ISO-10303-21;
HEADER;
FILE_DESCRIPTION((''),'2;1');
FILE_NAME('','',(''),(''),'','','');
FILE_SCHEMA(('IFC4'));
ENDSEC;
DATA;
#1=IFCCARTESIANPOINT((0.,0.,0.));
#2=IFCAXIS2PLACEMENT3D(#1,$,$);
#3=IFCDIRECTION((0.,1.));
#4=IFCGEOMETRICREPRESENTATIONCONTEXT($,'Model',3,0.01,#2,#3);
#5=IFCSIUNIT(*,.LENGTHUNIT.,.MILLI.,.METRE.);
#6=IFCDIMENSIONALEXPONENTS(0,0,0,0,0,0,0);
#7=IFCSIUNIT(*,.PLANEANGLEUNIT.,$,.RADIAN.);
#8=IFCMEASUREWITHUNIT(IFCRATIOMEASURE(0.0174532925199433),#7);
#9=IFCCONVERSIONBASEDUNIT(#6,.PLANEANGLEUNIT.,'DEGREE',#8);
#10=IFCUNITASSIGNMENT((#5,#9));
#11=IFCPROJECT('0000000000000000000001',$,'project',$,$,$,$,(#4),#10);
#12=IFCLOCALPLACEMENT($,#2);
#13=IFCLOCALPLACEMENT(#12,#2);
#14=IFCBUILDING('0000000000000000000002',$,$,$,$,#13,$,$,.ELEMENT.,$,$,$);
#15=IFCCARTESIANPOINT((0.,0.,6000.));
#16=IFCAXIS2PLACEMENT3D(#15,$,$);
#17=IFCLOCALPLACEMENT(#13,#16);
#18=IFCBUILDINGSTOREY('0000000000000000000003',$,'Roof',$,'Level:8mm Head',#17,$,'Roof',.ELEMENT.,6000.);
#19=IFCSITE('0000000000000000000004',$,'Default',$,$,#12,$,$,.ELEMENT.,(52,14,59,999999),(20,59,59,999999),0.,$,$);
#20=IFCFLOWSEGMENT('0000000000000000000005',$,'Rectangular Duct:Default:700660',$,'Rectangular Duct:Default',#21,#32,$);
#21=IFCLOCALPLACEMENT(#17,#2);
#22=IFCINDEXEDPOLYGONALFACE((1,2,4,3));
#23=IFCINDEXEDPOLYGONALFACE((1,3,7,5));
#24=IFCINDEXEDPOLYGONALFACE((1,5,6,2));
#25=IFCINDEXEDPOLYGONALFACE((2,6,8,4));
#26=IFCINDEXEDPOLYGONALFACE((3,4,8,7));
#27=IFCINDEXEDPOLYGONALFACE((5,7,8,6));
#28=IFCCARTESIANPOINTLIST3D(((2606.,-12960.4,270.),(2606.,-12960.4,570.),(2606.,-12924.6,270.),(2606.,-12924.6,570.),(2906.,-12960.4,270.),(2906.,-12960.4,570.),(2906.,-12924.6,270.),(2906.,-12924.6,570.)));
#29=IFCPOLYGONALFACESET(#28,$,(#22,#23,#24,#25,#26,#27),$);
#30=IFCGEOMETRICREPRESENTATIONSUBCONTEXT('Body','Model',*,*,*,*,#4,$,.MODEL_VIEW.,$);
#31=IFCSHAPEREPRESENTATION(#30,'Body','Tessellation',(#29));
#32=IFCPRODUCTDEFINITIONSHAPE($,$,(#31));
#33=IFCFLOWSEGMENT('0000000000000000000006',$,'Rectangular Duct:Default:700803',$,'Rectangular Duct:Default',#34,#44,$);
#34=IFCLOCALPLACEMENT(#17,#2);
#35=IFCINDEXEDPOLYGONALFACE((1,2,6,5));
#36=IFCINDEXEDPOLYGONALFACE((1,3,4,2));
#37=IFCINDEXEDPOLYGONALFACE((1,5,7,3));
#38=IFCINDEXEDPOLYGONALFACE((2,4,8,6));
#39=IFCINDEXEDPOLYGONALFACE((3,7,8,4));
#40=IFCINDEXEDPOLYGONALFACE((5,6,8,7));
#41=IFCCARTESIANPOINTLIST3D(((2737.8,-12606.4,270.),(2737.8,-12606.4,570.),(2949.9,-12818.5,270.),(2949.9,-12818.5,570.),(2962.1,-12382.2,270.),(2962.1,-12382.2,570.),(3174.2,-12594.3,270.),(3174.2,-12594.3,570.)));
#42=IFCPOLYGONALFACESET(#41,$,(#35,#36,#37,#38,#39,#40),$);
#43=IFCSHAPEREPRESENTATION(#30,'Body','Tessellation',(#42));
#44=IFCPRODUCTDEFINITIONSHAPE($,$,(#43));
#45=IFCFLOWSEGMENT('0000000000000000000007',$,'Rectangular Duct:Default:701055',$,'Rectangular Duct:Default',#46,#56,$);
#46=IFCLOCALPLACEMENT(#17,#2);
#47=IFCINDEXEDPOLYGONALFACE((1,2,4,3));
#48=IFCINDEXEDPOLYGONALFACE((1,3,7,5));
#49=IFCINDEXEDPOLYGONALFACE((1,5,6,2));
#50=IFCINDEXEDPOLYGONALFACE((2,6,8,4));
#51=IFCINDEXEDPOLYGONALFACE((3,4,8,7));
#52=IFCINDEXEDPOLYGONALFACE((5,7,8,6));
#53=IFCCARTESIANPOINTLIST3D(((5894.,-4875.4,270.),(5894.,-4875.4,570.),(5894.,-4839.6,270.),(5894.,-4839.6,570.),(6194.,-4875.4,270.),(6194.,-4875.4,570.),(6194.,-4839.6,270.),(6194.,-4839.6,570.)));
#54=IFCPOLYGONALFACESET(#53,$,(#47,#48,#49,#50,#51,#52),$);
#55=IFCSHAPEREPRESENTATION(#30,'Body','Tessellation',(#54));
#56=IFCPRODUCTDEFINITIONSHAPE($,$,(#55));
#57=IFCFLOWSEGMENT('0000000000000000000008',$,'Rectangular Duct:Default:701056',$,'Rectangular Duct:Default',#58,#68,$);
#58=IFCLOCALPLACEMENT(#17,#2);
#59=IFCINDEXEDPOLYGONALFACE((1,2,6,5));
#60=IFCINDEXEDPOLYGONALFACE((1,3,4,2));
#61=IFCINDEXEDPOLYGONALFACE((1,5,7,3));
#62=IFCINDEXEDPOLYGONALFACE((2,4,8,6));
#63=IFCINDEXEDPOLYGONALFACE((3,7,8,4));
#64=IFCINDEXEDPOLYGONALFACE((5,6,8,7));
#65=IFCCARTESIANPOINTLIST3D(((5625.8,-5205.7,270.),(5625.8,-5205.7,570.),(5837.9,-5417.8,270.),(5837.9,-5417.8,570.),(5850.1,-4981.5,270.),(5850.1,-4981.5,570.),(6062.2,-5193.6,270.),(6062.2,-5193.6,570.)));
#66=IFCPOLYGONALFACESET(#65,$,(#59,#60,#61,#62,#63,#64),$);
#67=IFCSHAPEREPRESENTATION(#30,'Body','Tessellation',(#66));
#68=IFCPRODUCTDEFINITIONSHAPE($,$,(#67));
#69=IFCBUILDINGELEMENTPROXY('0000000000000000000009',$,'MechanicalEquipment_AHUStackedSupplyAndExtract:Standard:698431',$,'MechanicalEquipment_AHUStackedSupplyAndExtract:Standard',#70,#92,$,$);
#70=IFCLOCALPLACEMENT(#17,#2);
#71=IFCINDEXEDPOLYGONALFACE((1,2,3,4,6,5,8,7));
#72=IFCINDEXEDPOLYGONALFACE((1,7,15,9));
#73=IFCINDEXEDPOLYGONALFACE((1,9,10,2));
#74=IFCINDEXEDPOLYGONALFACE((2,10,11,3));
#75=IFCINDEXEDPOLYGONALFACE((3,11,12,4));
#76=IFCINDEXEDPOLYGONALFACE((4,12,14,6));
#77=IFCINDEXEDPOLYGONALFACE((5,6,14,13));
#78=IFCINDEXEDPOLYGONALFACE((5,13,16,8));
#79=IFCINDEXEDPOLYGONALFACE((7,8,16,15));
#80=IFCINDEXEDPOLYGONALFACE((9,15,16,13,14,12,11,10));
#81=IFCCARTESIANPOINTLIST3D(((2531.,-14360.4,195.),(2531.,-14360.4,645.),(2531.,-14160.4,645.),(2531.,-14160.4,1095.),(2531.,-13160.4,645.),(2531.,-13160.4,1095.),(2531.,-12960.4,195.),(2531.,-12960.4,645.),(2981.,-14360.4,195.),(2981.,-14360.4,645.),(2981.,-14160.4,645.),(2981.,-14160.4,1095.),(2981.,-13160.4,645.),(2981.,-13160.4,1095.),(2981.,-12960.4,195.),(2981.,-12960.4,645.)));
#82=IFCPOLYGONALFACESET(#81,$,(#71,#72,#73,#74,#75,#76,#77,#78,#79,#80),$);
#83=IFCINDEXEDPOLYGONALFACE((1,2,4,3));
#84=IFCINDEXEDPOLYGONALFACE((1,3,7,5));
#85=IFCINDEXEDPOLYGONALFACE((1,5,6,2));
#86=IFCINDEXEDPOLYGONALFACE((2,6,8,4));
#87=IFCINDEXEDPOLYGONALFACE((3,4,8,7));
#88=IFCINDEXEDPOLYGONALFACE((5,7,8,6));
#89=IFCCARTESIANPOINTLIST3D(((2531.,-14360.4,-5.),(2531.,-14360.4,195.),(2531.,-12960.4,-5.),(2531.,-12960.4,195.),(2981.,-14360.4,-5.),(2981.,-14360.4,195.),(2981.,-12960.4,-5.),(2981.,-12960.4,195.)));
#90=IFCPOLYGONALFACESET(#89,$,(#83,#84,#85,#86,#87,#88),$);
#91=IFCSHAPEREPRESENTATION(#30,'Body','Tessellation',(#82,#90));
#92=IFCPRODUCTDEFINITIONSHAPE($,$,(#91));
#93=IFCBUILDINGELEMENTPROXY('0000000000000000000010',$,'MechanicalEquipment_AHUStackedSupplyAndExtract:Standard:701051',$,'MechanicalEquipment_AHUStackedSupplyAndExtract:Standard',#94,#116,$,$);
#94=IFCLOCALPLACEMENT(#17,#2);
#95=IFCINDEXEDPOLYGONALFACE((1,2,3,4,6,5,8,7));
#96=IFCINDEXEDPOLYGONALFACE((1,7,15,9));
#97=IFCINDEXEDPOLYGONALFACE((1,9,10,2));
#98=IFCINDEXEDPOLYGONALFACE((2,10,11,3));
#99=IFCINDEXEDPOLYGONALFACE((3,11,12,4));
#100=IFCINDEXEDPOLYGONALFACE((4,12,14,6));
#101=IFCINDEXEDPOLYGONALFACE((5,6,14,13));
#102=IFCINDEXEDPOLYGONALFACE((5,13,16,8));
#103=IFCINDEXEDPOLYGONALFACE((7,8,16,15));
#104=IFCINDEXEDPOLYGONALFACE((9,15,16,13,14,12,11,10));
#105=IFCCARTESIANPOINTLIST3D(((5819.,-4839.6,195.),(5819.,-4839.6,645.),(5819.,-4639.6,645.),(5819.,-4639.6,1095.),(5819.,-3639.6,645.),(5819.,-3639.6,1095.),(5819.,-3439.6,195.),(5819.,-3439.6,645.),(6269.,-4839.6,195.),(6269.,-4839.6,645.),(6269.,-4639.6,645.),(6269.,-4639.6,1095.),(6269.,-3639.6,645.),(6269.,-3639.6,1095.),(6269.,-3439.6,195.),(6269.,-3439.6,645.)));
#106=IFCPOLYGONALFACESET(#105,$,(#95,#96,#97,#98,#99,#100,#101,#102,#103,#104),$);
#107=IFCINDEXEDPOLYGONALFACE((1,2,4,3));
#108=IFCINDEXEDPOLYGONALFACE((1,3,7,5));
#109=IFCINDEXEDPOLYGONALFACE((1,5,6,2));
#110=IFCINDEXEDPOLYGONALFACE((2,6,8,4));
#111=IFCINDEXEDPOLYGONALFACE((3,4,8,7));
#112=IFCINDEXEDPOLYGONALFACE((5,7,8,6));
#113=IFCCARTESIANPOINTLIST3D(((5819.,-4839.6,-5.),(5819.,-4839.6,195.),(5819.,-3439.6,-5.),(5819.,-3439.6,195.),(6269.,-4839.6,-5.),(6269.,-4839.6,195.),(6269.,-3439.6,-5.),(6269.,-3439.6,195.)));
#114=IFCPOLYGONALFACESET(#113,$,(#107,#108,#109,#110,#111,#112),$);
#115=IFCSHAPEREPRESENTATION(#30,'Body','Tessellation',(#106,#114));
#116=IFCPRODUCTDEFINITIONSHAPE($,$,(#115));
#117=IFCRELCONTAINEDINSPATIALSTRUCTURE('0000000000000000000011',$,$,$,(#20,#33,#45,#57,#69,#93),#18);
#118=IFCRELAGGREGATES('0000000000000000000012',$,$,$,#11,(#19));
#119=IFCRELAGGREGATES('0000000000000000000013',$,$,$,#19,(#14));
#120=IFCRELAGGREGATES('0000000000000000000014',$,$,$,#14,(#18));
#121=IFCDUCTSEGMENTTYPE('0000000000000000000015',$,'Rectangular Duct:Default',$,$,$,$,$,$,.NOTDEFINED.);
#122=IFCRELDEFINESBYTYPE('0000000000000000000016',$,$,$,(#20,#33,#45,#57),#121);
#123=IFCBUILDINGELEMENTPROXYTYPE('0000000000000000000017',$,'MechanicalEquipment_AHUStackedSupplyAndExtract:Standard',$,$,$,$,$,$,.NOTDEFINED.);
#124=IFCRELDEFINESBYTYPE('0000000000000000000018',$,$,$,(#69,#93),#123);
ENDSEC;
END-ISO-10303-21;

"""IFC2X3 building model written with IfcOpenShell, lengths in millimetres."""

from ifc_helpers import new_model, entity, si_unit, converted_unit, direction, frame, frame_2d, origin, origin_2d_with_axis, place, context, subcontext, project, spatial, polyline, rectangle, outline, extrude, source, transform, mapped, type_object, type_shapes, element, save


model = new_model("IFC2X3")

# Units and contexts
model_context = context("Model", 3, precision=0.01, world=origin(), true_north=direction((0.0, 1.0)))
body_context = subcontext(model_context, "Body", "Model", "MODEL_VIEW")
ifc_project = project(units=[si_unit("LENGTHUNIT", "METRE", prefix="MILLI"), converted_unit("PLANEANGLEUNIT", "DEGREE", entity("IfcRatioMeasure", 0.0174532925199433), si_unit("PLANEANGLEUNIT", "RADIAN"), dimensions=[0, 0, 0, 0, 0, 0, 0])], contexts=[model_context])

# Site, building, storey
site_placement = place(None, origin())
site = spatial("IfcSite", under=ifc_project, at=site_placement, Name="Default", CompositionType="ELEMENT", RefLatitude=(52, 14, 59, 999999), RefLongitude=(20, 59, 59, 999999), RefElevation=0.0)
building_placement = place(site_placement, origin())
building = spatial("IfcBuilding", under=site, at=building_placement, CompositionType="ELEMENT")
storey_placement = place(building_placement, frame((0.0, 0.0, 6000.0)))
storey = spatial("IfcBuildingStorey", under=building, at=storey_placement, Name="Roof", ObjectType="Level:8mm Head", LongName="Roof", CompositionType="ELEMENT", Elevation=6000.0)

# Flow segments
duct_segment_type = type_object("IfcDuctSegmentType", Name="Rectangular Duct:Default", PredefinedType="NOTDEFINED")
flow_segment_1_placement = place(storey_placement, origin())
element("IfcFlowSegment", 1, at=flow_segment_1_placement, inside=storey, type_object=duct_segment_type, Name="Rectangular Duct:Default:700660", ObjectType="Rectangular Duct:Default", context=body_context, shape_type="SweptSolid", body=[
    extrude(rectangle(XDim=35.7, YDim=300.0, at=frame_2d((0.0, 0.0), x_axis=(1.0, 0.0))), frame((2756.0, -12942.5, 270.0), z_axis=(0.0, 0.0, 1.0), x_axis=(0.0, 1.0, 0.0)), (0.0, 0.0, 1.0), 300.0),
])
flow_segment_2_placement = place(storey_placement, origin())
element("IfcFlowSegment", 2, at=flow_segment_2_placement, inside=storey, type_object=duct_segment_type, Name="Rectangular Duct:Default:700803", ObjectType="Rectangular Duct:Default", context=body_context, shape_type="SweptSolid", body=[
    extrude(rectangle(XDim=317.2, YDim=300.0, at=origin_2d_with_axis()), frame((2956.0, -12600.4, 270.0), z_axis=(0.0, 0.0, 1.0), x_axis=(-0.707107, -0.707107, 0.0)), (0.0, 0.0, 1.0), 300.0),
])
flow_segment_3_placement = place(storey_placement, origin())
element("IfcFlowSegment", 3, at=flow_segment_3_placement, inside=storey, type_object=duct_segment_type, Name="Rectangular Duct:Default:701055", ObjectType="Rectangular Duct:Default", context=body_context, shape_type="SweptSolid", body=[
    extrude(rectangle(XDim=35.7, YDim=300.0, at=frame_2d((0.0, 0.0), x_axis=(1.0, 0.0))), frame((6044.0, -4857.5, 270.0), z_axis=(0.0, 0.0, 1.0), x_axis=(0.0, -1.0, 0.0)), (0.0, 0.0, 1.0), 300.0),
])
flow_segment_4_placement = place(storey_placement, origin())
element("IfcFlowSegment", 4, at=flow_segment_4_placement, inside=storey, type_object=duct_segment_type, Name="Rectangular Duct:Default:701056", ObjectType="Rectangular Duct:Default", context=body_context, shape_type="SweptSolid", body=[
    extrude(rectangle(XDim=317.2, YDim=300.0, at=frame_2d((0.0, 0.0), x_axis=(1.0, 0.0))), frame((5844.0, -5199.6, 270.0), z_axis=(0.0, 0.0, 1.0), x_axis=(0.707107, 0.707107, 0.0)), (0.0, 0.0, 1.0), 300.0),
])

# Building element proxies
building_element_proxy_type = type_object("IfcBuildingElementProxyType", Name="MechanicalEquipment_AHUStackedSupplyAndExtract:Standard", PredefinedType="NOTDEFINED")
shared_shape_1 = source(origin(), body_context, "Body", "SweptSolid", [
    extrude(outline(polyline([(-700.0, 0.0), (-700.0, -450.0), (700.0, -450.0), (700.0, 0.0), (500.0, 0.0), (500.0, 450.0), (-500.0, 450.0), (-500.0, 0.0), (-700.0, 0.0)])), frame((-515.0, -225.0, 450.0), z_axis=(0.0, -1.0, 0.0), x_axis=(1.0, 0.0, 0.0)), (0.0, 0.0, -1.0), 450.0),
    extrude(rectangle(XDim=450.0, YDim=1400.0, at=origin_2d_with_axis()), frame((-515.0, 0.0, -200.0), z_axis=(0.0, 0.0, 1.0), x_axis=(0.0, 1.0, 0.0)), (0.0, 0.0, 1.0), 200.0),
])
type_shapes(building_element_proxy_type, [shared_shape_1])
for number, where, z_axis, x_axis, name in (
    (5, (2756.0, -13145.4, 195.0), (0.0, 0.0, 1.0), (0.0, 1.0, 0.0), "MechanicalEquipment_AHUStackedSupplyAndExtract:Standard:698431"),
    (6, (6044.0, -4654.6, 195.0), (0.0, 0.0, 1.0), (0.0, -1.0, 0.0), "MechanicalEquipment_AHUStackedSupplyAndExtract:Standard:701051"),
):
    element("IfcBuildingElementProxy", number, at=place(storey_placement, frame(where, z_axis=z_axis, x_axis=x_axis)), inside=storey, type_object=building_element_proxy_type, Name=name, ObjectType="MechanicalEquipment_AHUStackedSupplyAndExtract:Standard", context=body_context, shape_type="MappedRepresentation", body=[
        mapped(shared_shape_1, transform((0.0, 0.0, 0.0), scale=1.0)),
    ])

save(model, "model.ifc")
